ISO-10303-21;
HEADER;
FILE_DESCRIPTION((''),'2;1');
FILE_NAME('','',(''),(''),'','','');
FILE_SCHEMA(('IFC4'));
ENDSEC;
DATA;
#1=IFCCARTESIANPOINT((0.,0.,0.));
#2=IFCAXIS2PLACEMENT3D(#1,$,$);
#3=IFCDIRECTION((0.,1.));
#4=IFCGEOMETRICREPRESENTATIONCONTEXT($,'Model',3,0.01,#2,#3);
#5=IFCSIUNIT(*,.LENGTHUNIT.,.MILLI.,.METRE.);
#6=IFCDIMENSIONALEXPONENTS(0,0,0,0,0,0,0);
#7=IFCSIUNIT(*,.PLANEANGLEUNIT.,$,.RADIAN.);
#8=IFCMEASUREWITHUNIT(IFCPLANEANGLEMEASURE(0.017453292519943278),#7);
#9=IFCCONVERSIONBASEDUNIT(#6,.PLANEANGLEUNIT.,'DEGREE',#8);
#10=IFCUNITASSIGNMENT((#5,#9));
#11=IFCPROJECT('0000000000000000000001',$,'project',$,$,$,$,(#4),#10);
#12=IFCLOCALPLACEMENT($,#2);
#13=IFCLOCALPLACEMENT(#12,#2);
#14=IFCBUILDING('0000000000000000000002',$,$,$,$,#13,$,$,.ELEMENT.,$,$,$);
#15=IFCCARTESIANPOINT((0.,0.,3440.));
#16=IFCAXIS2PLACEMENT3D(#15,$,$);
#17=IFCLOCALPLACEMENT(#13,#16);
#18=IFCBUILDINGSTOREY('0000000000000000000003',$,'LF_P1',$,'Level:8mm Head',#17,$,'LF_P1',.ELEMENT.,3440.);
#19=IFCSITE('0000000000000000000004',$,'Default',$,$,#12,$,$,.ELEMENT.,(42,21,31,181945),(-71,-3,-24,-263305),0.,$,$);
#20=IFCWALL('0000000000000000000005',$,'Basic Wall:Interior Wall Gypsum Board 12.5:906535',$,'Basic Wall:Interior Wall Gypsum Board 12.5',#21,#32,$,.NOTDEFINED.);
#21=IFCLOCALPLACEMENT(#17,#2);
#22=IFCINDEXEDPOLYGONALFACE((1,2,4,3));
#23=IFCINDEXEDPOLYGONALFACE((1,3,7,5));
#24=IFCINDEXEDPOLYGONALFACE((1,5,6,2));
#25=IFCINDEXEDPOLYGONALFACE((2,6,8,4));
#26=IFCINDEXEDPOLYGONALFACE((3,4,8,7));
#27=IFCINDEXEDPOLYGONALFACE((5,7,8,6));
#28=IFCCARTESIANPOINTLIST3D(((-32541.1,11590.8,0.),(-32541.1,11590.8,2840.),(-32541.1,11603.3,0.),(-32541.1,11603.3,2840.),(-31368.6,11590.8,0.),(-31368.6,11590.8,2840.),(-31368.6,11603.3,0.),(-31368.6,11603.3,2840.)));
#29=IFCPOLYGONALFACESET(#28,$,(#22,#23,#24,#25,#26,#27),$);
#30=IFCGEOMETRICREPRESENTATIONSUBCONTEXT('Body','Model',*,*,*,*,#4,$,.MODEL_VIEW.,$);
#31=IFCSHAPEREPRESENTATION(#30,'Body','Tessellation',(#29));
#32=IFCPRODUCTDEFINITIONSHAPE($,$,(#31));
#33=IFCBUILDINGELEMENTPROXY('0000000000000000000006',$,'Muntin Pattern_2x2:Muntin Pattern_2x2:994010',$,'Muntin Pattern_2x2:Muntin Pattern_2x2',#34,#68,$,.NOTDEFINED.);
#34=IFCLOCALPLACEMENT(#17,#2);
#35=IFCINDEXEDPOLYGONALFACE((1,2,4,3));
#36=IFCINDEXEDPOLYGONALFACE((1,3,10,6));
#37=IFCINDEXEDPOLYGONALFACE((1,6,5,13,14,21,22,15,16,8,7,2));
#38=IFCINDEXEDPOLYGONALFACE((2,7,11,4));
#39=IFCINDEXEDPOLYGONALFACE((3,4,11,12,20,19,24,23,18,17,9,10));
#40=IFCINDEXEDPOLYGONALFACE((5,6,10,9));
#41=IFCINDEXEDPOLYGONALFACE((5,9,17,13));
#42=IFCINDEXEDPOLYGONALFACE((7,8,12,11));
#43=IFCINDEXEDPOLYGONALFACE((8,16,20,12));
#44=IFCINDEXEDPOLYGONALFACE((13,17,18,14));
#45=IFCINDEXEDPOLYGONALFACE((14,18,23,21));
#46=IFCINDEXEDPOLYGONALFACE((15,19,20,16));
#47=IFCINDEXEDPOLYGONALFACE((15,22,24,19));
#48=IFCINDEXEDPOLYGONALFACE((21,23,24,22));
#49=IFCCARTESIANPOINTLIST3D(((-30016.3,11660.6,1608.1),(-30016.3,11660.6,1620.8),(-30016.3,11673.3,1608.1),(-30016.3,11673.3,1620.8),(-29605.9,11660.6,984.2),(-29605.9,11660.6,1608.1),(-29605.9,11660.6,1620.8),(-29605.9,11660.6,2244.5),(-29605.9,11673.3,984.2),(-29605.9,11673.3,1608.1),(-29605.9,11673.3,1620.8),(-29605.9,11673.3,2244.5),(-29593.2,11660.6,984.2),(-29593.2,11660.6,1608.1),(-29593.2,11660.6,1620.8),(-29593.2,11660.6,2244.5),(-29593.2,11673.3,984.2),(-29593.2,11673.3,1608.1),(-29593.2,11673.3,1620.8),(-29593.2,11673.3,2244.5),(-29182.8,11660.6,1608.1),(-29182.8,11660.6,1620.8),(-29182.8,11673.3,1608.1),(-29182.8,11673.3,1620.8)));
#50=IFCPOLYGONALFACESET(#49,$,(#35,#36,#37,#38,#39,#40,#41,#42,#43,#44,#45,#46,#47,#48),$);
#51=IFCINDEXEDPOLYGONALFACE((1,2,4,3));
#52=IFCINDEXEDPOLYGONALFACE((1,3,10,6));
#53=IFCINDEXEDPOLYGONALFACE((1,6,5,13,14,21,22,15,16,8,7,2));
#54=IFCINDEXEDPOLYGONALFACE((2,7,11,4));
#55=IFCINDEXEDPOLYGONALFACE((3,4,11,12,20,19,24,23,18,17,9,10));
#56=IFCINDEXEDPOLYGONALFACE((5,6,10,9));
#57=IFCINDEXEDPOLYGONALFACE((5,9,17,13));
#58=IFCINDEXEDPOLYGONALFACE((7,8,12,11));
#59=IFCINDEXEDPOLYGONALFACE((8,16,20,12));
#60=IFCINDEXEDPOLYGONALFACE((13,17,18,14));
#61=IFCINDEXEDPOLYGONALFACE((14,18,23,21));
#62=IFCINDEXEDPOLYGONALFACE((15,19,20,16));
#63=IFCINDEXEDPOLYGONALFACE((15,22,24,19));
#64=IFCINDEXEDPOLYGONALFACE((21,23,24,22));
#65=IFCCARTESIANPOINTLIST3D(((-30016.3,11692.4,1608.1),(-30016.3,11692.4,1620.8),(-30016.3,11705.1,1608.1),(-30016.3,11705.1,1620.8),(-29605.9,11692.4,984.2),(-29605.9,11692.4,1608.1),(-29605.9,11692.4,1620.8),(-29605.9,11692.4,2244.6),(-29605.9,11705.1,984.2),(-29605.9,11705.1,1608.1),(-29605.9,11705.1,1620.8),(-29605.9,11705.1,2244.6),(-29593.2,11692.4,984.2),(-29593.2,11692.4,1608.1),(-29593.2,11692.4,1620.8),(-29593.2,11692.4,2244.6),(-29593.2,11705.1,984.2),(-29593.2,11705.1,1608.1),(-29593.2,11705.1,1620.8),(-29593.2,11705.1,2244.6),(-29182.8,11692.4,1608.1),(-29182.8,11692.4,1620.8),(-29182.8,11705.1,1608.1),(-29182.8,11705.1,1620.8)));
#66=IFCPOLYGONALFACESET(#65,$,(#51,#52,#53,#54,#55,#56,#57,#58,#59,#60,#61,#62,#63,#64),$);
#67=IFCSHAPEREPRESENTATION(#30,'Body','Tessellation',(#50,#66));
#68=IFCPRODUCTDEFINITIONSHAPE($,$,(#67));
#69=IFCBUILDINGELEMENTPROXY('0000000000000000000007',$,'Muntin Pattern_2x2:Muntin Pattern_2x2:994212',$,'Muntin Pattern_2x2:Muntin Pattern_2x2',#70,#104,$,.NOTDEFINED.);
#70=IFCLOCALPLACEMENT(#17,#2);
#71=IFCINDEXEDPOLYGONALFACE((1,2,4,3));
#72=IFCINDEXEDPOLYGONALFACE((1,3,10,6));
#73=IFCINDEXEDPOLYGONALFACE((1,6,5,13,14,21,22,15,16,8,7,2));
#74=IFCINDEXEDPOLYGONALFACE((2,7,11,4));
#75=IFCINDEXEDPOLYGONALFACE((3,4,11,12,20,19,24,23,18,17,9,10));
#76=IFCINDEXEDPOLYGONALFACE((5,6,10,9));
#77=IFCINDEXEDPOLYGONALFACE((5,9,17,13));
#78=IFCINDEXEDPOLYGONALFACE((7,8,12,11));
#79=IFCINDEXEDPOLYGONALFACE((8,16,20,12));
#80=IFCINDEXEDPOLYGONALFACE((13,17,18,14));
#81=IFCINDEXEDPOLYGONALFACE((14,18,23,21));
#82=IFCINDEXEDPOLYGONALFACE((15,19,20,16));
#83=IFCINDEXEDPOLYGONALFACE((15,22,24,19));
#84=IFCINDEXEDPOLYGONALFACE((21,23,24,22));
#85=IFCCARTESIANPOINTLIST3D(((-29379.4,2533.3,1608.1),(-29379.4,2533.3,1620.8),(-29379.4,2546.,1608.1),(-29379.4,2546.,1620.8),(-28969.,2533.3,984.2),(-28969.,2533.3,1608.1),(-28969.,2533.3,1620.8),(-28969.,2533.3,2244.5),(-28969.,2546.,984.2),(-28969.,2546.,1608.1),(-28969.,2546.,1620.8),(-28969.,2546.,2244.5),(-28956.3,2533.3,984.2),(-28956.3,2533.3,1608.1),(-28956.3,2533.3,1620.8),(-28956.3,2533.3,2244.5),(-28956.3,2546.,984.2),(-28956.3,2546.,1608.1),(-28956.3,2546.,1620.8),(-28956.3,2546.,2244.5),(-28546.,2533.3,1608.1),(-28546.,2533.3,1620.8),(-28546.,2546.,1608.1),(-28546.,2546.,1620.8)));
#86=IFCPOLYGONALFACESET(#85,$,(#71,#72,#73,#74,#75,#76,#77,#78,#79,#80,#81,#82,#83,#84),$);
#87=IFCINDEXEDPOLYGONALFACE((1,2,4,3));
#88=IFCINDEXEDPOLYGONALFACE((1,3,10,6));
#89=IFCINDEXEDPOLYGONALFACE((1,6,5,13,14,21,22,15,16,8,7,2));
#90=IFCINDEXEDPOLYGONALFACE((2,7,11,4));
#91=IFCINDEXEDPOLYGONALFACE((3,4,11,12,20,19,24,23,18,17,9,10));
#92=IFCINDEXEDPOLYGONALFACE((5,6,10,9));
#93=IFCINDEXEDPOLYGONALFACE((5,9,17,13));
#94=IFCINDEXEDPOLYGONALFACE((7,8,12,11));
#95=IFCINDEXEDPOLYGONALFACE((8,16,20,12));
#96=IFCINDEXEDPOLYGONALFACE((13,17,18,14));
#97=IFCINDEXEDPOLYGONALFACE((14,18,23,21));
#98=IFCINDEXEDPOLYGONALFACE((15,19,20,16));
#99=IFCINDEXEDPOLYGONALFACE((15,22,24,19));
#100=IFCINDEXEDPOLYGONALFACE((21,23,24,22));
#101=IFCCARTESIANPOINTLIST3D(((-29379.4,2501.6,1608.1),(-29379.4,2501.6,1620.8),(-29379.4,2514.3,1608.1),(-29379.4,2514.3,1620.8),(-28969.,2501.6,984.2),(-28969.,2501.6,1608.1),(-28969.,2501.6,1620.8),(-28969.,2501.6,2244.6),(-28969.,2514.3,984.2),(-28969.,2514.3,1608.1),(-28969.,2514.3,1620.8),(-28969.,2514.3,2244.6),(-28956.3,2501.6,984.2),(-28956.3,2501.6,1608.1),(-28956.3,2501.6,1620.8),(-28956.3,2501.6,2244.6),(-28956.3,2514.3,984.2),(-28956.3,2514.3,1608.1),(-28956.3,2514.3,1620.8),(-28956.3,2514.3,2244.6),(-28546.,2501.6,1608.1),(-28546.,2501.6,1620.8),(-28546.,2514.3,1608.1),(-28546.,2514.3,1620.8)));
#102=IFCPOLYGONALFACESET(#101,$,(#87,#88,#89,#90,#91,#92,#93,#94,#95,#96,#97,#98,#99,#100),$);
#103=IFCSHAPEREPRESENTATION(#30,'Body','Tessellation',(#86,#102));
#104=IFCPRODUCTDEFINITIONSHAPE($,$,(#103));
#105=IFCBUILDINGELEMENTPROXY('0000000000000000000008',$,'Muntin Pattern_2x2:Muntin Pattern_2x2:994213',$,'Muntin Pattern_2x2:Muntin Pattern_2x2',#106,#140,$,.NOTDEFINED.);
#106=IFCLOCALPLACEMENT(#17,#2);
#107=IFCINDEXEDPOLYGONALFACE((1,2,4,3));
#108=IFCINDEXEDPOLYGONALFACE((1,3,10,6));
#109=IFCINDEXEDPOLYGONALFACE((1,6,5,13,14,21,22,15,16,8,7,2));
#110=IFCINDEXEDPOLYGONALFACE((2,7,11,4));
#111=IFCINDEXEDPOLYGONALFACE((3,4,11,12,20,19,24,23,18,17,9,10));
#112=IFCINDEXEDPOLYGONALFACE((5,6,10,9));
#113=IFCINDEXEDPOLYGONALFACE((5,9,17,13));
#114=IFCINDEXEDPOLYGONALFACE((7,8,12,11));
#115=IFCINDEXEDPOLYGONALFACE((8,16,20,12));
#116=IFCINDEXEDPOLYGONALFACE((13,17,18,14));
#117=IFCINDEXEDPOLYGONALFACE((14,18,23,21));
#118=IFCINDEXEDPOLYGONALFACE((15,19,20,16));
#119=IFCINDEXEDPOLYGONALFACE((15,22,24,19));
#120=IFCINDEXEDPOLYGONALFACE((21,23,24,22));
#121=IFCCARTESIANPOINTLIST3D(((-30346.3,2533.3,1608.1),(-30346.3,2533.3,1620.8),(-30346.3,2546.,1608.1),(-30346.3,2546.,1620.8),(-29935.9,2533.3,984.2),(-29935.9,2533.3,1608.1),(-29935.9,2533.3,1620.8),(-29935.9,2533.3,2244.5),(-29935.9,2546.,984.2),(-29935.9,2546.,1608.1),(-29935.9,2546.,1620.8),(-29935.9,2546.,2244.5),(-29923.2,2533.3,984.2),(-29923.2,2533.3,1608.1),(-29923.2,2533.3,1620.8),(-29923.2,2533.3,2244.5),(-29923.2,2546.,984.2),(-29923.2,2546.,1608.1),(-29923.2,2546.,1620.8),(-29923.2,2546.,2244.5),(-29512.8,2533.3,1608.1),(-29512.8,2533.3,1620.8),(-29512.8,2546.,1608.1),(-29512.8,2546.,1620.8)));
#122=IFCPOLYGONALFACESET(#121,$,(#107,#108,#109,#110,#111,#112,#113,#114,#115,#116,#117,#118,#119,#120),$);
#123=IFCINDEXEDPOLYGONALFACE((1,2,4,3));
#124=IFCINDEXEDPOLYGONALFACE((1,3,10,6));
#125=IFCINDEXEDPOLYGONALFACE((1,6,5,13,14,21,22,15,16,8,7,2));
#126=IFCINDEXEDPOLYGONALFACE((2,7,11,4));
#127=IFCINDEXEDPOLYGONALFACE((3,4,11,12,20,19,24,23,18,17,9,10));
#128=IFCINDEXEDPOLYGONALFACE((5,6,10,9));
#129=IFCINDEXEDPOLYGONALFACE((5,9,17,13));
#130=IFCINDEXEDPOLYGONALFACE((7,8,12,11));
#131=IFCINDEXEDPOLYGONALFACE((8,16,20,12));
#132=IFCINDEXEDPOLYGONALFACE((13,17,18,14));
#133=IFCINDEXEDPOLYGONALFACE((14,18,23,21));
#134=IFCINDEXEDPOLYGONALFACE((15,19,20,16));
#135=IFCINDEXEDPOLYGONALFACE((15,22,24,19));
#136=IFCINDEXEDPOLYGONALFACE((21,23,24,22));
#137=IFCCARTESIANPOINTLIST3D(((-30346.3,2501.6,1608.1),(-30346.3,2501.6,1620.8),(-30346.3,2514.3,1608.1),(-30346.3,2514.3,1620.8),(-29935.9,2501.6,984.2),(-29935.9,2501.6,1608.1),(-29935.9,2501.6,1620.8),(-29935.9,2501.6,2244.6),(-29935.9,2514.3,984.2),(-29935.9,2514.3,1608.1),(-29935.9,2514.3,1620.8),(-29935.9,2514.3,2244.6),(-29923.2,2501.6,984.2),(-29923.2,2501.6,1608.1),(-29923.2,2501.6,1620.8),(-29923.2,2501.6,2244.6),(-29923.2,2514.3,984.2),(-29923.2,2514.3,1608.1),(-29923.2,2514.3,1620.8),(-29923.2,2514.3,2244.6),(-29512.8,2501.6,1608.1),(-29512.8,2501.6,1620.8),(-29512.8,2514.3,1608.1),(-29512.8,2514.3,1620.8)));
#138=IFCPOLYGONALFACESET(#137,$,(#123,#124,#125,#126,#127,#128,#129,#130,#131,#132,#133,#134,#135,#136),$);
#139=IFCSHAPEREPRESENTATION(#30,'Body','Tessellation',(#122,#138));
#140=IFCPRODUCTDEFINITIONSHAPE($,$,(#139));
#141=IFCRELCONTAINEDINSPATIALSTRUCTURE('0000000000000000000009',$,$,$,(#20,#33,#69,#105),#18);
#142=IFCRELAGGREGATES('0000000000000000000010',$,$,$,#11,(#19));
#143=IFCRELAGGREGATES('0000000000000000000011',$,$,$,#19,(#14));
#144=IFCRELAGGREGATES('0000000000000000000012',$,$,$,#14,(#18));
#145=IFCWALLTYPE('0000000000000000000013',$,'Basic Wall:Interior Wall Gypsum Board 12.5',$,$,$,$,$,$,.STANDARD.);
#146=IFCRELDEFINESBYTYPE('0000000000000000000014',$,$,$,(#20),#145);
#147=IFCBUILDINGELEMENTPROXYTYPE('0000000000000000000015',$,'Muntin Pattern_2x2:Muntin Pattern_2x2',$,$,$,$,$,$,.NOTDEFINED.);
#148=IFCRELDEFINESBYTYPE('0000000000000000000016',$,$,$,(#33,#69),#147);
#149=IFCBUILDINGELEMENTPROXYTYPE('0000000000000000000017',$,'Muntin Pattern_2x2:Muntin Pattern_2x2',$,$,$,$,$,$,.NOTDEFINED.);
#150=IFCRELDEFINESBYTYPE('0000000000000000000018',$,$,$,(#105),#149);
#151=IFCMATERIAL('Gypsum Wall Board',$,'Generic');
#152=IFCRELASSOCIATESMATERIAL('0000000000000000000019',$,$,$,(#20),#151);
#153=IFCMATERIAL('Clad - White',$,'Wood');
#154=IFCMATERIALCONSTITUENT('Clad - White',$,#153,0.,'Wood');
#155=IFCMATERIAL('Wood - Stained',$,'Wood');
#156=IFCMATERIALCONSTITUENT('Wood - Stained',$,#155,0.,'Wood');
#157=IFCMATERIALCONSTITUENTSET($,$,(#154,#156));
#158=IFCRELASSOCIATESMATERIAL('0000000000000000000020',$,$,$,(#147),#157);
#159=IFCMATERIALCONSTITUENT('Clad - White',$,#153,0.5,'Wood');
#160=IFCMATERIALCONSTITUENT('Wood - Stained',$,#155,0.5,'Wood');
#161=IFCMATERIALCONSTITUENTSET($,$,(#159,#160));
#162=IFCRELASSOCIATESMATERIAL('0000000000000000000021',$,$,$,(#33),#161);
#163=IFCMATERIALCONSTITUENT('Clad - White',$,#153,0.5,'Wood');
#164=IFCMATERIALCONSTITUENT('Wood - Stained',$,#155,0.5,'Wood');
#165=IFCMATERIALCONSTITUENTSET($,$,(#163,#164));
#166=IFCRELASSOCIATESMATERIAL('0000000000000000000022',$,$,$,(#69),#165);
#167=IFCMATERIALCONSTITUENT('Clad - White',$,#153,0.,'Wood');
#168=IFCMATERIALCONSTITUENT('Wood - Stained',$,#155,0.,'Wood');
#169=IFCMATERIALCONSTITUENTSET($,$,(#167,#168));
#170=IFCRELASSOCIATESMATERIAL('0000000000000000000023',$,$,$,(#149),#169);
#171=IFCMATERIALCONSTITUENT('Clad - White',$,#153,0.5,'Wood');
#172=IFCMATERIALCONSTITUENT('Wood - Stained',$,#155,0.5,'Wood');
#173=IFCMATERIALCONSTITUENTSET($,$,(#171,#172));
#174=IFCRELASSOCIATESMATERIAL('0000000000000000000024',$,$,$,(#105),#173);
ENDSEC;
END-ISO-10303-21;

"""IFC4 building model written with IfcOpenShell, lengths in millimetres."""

from ifc_helpers import new_model, entity, si_unit, converted_unit, direction, frame, origin, place, context, subcontext, project, spatial, indexed_curve, outline, extrude, source, transform, mapped, material, constituent, constituent_set, type_object, type_shapes, element, save


model = new_model("IFC4")

# Units and contexts
model_context = context("Model", 3, precision=0.01, world=origin(), true_north=direction((0.0, 1.0)))
body_context = subcontext(model_context, "Body", "Model", "MODEL_VIEW")
ifc_project = project(units=[si_unit("LENGTHUNIT", "METRE", prefix="MILLI"), converted_unit("PLANEANGLEUNIT", "DEGREE", entity("IfcPlaneAngleMeasure", 0.017453292519943278), si_unit("PLANEANGLEUNIT", "RADIAN"), dimensions=[0, 0, 0, 0, 0, 0, 0])], contexts=[model_context])

# Site, building, storey
site_placement = place(None, origin())
site = spatial("IfcSite", under=ifc_project, at=site_placement, Name="Default", CompositionType="ELEMENT", RefLatitude=(42, 21, 31, 181945), RefLongitude=(-71, -3, -24, -263305), RefElevation=0.0)
building_placement = place(site_placement, origin())
building = spatial("IfcBuilding", under=site, at=building_placement, CompositionType="ELEMENT")
storey_placement = place(building_placement, frame((0.0, 0.0, 3440.0)))
storey = spatial("IfcBuildingStorey", under=building, at=storey_placement, Name="LF_P1", ObjectType="Level:8mm Head", LongName="LF_P1", CompositionType="ELEMENT", Elevation=3440.0)

# Wall
ifc_material_1 = material(Name="Gypsum Wall Board", Category="Generic")
wall_type_1 = type_object("IfcWallType", Name="Basic Wall:Interior Wall Gypsum Board 12.5", PredefinedType="STANDARD")
wall_1_placement = place(storey_placement, frame((-32541.1, 11597.1, 0.0)))
element("IfcWall", 1, at=wall_1_placement, inside=storey, type_object=wall_type_1, material=ifc_material_1, Name="Basic Wall:Interior Wall Gypsum Board 12.5:906535", ObjectType="Basic Wall:Interior Wall Gypsum Board 12.5", PredefinedType="NOTDEFINED", context=body_context, shape_type="SweptSolid", body=[
    extrude(outline(indexed_curve([(1172.5, 6.3), (0.0, 6.3), (0.0, -6.3), (1172.5, -6.3), (1172.5, 6.3)], self_intersect=False)), origin(), (0.0, 0.0, 1.0), 2840.0),
])

# Building element proxies
ifc_material_2 = material(Name="Clad - White", Category="Wood")
ifc_constituent_1 = constituent(ifc_material_2, Name="Clad - White", Category="Wood", fraction=0.5)
ifc_material_3 = material(Name="Wood - Stained", Category="Wood")
ifc_constituent_2 = constituent(ifc_material_3, Name="Wood - Stained", Category="Wood", fraction=0.5)
ifc_constituent_set_1 = constituent_set(constituents=[ifc_constituent_1, ifc_constituent_2])
ifc_constituent_3 = constituent(ifc_material_2, Name="Clad - White", Category="Wood", fraction=0.0)
ifc_constituent_4 = constituent(ifc_material_3, Name="Wood - Stained", Category="Wood", fraction=0.0)
ifc_constituent_set_2 = constituent_set(constituents=[ifc_constituent_3, ifc_constituent_4])
building_element_proxy_type_1 = type_object("IfcBuildingElementProxyType", Name="Muntin Pattern_2x2:Muntin Pattern_2x2", PredefinedType="NOTDEFINED", material=ifc_constituent_set_2)
shared_shape_1 = source(origin(), body_context, "Body", "SweptSolid", [
    extrude(outline(indexed_curve([(6.4, -6.4), (630.1, -6.4), (630.1, 6.3), (6.4, 6.3), (6.4, 416.7), (-6.3, 416.7), (-6.3, 6.3), (-630.2, 6.3), (-630.2, -6.4), (-6.3, -6.4), (-6.3, -416.7), (6.4, -416.7), (6.4, -6.4)], self_intersect=False)), frame((0.0, -22.2, 630.1), z_axis=(0.0, 1.0, 0.0), x_axis=(0.0, 0.0, 1.0)), (0.0, 0.0, 1.0), 12.7),
    extrude(outline(indexed_curve([(6.4, -6.4), (630.2, -6.4), (630.2, 6.3), (6.4, 6.3), (6.4, 416.7), (-6.3, 416.7), (-6.3, 6.3), (-630.2, 6.3), (-630.2, -6.4), (-6.3, -6.4), (-6.3, -416.7), (6.4, -416.7), (6.4, -6.4)], self_intersect=False)), frame((0.0, 9.5, 630.2), z_axis=(0.0, 1.0, 0.0), x_axis=(0.0, 0.0, 1.0)), (0.0, 0.0, 1.0), 12.7),
])
type_shapes(building_element_proxy_type_1, [shared_shape_1])
proxy_1_placement = place(storey_placement, frame((-29599.5, 11682.9, 984.3)))
element("IfcBuildingElementProxy", 2, at=proxy_1_placement, inside=storey, type_object=building_element_proxy_type_1, material=ifc_constituent_set_1, Name="Muntin Pattern_2x2:Muntin Pattern_2x2:994010", ObjectType="Muntin Pattern_2x2:Muntin Pattern_2x2", PredefinedType="NOTDEFINED", context=body_context, shape_type="MappedRepresentation", body=[
    mapped(shared_shape_1, transform((0.0, 0.0, 0.0), scale=1.0)),
])
ifc_constituent_5 = constituent(ifc_material_2, Name="Clad - White", Category="Wood", fraction=0.5)
ifc_constituent_6 = constituent(ifc_material_3, Name="Wood - Stained", Category="Wood", fraction=0.5)
ifc_constituent_set_3 = constituent_set(constituents=[ifc_constituent_5, ifc_constituent_6])
proxy_2_placement = place(storey_placement, frame((-28962.7, 2523.8, 984.3), z_axis=(0.0, 0.0, 1.0), x_axis=(-1.0, 0.0, 0.0)))
element("IfcBuildingElementProxy", 3, at=proxy_2_placement, inside=storey, type_object=building_element_proxy_type_1, material=ifc_constituent_set_3, Name="Muntin Pattern_2x2:Muntin Pattern_2x2:994212", ObjectType="Muntin Pattern_2x2:Muntin Pattern_2x2", PredefinedType="NOTDEFINED", context=body_context, shape_type="MappedRepresentation", body=[
    mapped(shared_shape_1, transform((0.0, 0.0, 0.0), scale=1.0)),
])
ifc_constituent_7 = constituent(ifc_material_2, Name="Clad - White", Category="Wood", fraction=0.5)
ifc_constituent_8 = constituent(ifc_material_3, Name="Wood - Stained", Category="Wood", fraction=0.5)
ifc_constituent_set_4 = constituent_set(constituents=[ifc_constituent_7, ifc_constituent_8])
ifc_constituent_9 = constituent(ifc_material_2, Name="Clad - White", Category="Wood", fraction=0.0)
ifc_constituent_10 = constituent(ifc_material_3, Name="Wood - Stained", Category="Wood", fraction=0.0)
ifc_constituent_set_5 = constituent_set(constituents=[ifc_constituent_9, ifc_constituent_10])
building_element_proxy_type_2 = type_object("IfcBuildingElementProxyType", Name="Muntin Pattern_2x2:Muntin Pattern_2x2", PredefinedType="NOTDEFINED", material=ifc_constituent_set_5)
shared_shape_2 = source(origin(), body_context, "Body", "SweptSolid", [
    extrude(outline(indexed_curve([(6.4, -6.4), (630.1, -6.4), (630.1, 6.3), (6.4, 6.3), (6.4, 416.7), (-6.3, 416.7), (-6.3, 6.3), (-630.2, 6.3), (-630.2, -6.4), (-6.3, -6.4), (-6.3, -416.7), (6.4, -416.7), (6.4, -6.4)], self_intersect=False)), frame((0.0, 9.5, 630.1), z_axis=(0.0, 1.0, 0.0), x_axis=(0.0, 0.0, 1.0)), (0.0, 0.0, 1.0), 12.7),
    extrude(outline(indexed_curve([(6.4, -6.4), (630.2, -6.4), (630.2, 6.3), (6.4, 6.3), (6.4, 416.7), (-6.3, 416.7), (-6.3, 6.3), (-630.2, 6.3), (-630.2, -6.4), (-6.3, -6.4), (-6.3, -416.7), (6.4, -416.7), (6.4, -6.4)], self_intersect=False)), frame((0.0, -22.2, 630.2), z_axis=(0.0, 1.0, 0.0), x_axis=(0.0, 0.0, 1.0)), (0.0, 0.0, 1.0), 12.7),
])
type_shapes(building_element_proxy_type_2, [shared_shape_2])
proxy_3_placement = place(storey_placement, frame((-29929.5, 2523.8, 984.3)))
element("IfcBuildingElementProxy", 4, at=proxy_3_placement, inside=storey, type_object=building_element_proxy_type_2, material=ifc_constituent_set_4, Name="Muntin Pattern_2x2:Muntin Pattern_2x2:994213", ObjectType="Muntin Pattern_2x2:Muntin Pattern_2x2", PredefinedType="NOTDEFINED", context=body_context, shape_type="MappedRepresentation", body=[
    mapped(shared_shape_2, transform((0.0, 0.0, 0.0), scale=1.0)),
])

save(model, "model.ifc")
